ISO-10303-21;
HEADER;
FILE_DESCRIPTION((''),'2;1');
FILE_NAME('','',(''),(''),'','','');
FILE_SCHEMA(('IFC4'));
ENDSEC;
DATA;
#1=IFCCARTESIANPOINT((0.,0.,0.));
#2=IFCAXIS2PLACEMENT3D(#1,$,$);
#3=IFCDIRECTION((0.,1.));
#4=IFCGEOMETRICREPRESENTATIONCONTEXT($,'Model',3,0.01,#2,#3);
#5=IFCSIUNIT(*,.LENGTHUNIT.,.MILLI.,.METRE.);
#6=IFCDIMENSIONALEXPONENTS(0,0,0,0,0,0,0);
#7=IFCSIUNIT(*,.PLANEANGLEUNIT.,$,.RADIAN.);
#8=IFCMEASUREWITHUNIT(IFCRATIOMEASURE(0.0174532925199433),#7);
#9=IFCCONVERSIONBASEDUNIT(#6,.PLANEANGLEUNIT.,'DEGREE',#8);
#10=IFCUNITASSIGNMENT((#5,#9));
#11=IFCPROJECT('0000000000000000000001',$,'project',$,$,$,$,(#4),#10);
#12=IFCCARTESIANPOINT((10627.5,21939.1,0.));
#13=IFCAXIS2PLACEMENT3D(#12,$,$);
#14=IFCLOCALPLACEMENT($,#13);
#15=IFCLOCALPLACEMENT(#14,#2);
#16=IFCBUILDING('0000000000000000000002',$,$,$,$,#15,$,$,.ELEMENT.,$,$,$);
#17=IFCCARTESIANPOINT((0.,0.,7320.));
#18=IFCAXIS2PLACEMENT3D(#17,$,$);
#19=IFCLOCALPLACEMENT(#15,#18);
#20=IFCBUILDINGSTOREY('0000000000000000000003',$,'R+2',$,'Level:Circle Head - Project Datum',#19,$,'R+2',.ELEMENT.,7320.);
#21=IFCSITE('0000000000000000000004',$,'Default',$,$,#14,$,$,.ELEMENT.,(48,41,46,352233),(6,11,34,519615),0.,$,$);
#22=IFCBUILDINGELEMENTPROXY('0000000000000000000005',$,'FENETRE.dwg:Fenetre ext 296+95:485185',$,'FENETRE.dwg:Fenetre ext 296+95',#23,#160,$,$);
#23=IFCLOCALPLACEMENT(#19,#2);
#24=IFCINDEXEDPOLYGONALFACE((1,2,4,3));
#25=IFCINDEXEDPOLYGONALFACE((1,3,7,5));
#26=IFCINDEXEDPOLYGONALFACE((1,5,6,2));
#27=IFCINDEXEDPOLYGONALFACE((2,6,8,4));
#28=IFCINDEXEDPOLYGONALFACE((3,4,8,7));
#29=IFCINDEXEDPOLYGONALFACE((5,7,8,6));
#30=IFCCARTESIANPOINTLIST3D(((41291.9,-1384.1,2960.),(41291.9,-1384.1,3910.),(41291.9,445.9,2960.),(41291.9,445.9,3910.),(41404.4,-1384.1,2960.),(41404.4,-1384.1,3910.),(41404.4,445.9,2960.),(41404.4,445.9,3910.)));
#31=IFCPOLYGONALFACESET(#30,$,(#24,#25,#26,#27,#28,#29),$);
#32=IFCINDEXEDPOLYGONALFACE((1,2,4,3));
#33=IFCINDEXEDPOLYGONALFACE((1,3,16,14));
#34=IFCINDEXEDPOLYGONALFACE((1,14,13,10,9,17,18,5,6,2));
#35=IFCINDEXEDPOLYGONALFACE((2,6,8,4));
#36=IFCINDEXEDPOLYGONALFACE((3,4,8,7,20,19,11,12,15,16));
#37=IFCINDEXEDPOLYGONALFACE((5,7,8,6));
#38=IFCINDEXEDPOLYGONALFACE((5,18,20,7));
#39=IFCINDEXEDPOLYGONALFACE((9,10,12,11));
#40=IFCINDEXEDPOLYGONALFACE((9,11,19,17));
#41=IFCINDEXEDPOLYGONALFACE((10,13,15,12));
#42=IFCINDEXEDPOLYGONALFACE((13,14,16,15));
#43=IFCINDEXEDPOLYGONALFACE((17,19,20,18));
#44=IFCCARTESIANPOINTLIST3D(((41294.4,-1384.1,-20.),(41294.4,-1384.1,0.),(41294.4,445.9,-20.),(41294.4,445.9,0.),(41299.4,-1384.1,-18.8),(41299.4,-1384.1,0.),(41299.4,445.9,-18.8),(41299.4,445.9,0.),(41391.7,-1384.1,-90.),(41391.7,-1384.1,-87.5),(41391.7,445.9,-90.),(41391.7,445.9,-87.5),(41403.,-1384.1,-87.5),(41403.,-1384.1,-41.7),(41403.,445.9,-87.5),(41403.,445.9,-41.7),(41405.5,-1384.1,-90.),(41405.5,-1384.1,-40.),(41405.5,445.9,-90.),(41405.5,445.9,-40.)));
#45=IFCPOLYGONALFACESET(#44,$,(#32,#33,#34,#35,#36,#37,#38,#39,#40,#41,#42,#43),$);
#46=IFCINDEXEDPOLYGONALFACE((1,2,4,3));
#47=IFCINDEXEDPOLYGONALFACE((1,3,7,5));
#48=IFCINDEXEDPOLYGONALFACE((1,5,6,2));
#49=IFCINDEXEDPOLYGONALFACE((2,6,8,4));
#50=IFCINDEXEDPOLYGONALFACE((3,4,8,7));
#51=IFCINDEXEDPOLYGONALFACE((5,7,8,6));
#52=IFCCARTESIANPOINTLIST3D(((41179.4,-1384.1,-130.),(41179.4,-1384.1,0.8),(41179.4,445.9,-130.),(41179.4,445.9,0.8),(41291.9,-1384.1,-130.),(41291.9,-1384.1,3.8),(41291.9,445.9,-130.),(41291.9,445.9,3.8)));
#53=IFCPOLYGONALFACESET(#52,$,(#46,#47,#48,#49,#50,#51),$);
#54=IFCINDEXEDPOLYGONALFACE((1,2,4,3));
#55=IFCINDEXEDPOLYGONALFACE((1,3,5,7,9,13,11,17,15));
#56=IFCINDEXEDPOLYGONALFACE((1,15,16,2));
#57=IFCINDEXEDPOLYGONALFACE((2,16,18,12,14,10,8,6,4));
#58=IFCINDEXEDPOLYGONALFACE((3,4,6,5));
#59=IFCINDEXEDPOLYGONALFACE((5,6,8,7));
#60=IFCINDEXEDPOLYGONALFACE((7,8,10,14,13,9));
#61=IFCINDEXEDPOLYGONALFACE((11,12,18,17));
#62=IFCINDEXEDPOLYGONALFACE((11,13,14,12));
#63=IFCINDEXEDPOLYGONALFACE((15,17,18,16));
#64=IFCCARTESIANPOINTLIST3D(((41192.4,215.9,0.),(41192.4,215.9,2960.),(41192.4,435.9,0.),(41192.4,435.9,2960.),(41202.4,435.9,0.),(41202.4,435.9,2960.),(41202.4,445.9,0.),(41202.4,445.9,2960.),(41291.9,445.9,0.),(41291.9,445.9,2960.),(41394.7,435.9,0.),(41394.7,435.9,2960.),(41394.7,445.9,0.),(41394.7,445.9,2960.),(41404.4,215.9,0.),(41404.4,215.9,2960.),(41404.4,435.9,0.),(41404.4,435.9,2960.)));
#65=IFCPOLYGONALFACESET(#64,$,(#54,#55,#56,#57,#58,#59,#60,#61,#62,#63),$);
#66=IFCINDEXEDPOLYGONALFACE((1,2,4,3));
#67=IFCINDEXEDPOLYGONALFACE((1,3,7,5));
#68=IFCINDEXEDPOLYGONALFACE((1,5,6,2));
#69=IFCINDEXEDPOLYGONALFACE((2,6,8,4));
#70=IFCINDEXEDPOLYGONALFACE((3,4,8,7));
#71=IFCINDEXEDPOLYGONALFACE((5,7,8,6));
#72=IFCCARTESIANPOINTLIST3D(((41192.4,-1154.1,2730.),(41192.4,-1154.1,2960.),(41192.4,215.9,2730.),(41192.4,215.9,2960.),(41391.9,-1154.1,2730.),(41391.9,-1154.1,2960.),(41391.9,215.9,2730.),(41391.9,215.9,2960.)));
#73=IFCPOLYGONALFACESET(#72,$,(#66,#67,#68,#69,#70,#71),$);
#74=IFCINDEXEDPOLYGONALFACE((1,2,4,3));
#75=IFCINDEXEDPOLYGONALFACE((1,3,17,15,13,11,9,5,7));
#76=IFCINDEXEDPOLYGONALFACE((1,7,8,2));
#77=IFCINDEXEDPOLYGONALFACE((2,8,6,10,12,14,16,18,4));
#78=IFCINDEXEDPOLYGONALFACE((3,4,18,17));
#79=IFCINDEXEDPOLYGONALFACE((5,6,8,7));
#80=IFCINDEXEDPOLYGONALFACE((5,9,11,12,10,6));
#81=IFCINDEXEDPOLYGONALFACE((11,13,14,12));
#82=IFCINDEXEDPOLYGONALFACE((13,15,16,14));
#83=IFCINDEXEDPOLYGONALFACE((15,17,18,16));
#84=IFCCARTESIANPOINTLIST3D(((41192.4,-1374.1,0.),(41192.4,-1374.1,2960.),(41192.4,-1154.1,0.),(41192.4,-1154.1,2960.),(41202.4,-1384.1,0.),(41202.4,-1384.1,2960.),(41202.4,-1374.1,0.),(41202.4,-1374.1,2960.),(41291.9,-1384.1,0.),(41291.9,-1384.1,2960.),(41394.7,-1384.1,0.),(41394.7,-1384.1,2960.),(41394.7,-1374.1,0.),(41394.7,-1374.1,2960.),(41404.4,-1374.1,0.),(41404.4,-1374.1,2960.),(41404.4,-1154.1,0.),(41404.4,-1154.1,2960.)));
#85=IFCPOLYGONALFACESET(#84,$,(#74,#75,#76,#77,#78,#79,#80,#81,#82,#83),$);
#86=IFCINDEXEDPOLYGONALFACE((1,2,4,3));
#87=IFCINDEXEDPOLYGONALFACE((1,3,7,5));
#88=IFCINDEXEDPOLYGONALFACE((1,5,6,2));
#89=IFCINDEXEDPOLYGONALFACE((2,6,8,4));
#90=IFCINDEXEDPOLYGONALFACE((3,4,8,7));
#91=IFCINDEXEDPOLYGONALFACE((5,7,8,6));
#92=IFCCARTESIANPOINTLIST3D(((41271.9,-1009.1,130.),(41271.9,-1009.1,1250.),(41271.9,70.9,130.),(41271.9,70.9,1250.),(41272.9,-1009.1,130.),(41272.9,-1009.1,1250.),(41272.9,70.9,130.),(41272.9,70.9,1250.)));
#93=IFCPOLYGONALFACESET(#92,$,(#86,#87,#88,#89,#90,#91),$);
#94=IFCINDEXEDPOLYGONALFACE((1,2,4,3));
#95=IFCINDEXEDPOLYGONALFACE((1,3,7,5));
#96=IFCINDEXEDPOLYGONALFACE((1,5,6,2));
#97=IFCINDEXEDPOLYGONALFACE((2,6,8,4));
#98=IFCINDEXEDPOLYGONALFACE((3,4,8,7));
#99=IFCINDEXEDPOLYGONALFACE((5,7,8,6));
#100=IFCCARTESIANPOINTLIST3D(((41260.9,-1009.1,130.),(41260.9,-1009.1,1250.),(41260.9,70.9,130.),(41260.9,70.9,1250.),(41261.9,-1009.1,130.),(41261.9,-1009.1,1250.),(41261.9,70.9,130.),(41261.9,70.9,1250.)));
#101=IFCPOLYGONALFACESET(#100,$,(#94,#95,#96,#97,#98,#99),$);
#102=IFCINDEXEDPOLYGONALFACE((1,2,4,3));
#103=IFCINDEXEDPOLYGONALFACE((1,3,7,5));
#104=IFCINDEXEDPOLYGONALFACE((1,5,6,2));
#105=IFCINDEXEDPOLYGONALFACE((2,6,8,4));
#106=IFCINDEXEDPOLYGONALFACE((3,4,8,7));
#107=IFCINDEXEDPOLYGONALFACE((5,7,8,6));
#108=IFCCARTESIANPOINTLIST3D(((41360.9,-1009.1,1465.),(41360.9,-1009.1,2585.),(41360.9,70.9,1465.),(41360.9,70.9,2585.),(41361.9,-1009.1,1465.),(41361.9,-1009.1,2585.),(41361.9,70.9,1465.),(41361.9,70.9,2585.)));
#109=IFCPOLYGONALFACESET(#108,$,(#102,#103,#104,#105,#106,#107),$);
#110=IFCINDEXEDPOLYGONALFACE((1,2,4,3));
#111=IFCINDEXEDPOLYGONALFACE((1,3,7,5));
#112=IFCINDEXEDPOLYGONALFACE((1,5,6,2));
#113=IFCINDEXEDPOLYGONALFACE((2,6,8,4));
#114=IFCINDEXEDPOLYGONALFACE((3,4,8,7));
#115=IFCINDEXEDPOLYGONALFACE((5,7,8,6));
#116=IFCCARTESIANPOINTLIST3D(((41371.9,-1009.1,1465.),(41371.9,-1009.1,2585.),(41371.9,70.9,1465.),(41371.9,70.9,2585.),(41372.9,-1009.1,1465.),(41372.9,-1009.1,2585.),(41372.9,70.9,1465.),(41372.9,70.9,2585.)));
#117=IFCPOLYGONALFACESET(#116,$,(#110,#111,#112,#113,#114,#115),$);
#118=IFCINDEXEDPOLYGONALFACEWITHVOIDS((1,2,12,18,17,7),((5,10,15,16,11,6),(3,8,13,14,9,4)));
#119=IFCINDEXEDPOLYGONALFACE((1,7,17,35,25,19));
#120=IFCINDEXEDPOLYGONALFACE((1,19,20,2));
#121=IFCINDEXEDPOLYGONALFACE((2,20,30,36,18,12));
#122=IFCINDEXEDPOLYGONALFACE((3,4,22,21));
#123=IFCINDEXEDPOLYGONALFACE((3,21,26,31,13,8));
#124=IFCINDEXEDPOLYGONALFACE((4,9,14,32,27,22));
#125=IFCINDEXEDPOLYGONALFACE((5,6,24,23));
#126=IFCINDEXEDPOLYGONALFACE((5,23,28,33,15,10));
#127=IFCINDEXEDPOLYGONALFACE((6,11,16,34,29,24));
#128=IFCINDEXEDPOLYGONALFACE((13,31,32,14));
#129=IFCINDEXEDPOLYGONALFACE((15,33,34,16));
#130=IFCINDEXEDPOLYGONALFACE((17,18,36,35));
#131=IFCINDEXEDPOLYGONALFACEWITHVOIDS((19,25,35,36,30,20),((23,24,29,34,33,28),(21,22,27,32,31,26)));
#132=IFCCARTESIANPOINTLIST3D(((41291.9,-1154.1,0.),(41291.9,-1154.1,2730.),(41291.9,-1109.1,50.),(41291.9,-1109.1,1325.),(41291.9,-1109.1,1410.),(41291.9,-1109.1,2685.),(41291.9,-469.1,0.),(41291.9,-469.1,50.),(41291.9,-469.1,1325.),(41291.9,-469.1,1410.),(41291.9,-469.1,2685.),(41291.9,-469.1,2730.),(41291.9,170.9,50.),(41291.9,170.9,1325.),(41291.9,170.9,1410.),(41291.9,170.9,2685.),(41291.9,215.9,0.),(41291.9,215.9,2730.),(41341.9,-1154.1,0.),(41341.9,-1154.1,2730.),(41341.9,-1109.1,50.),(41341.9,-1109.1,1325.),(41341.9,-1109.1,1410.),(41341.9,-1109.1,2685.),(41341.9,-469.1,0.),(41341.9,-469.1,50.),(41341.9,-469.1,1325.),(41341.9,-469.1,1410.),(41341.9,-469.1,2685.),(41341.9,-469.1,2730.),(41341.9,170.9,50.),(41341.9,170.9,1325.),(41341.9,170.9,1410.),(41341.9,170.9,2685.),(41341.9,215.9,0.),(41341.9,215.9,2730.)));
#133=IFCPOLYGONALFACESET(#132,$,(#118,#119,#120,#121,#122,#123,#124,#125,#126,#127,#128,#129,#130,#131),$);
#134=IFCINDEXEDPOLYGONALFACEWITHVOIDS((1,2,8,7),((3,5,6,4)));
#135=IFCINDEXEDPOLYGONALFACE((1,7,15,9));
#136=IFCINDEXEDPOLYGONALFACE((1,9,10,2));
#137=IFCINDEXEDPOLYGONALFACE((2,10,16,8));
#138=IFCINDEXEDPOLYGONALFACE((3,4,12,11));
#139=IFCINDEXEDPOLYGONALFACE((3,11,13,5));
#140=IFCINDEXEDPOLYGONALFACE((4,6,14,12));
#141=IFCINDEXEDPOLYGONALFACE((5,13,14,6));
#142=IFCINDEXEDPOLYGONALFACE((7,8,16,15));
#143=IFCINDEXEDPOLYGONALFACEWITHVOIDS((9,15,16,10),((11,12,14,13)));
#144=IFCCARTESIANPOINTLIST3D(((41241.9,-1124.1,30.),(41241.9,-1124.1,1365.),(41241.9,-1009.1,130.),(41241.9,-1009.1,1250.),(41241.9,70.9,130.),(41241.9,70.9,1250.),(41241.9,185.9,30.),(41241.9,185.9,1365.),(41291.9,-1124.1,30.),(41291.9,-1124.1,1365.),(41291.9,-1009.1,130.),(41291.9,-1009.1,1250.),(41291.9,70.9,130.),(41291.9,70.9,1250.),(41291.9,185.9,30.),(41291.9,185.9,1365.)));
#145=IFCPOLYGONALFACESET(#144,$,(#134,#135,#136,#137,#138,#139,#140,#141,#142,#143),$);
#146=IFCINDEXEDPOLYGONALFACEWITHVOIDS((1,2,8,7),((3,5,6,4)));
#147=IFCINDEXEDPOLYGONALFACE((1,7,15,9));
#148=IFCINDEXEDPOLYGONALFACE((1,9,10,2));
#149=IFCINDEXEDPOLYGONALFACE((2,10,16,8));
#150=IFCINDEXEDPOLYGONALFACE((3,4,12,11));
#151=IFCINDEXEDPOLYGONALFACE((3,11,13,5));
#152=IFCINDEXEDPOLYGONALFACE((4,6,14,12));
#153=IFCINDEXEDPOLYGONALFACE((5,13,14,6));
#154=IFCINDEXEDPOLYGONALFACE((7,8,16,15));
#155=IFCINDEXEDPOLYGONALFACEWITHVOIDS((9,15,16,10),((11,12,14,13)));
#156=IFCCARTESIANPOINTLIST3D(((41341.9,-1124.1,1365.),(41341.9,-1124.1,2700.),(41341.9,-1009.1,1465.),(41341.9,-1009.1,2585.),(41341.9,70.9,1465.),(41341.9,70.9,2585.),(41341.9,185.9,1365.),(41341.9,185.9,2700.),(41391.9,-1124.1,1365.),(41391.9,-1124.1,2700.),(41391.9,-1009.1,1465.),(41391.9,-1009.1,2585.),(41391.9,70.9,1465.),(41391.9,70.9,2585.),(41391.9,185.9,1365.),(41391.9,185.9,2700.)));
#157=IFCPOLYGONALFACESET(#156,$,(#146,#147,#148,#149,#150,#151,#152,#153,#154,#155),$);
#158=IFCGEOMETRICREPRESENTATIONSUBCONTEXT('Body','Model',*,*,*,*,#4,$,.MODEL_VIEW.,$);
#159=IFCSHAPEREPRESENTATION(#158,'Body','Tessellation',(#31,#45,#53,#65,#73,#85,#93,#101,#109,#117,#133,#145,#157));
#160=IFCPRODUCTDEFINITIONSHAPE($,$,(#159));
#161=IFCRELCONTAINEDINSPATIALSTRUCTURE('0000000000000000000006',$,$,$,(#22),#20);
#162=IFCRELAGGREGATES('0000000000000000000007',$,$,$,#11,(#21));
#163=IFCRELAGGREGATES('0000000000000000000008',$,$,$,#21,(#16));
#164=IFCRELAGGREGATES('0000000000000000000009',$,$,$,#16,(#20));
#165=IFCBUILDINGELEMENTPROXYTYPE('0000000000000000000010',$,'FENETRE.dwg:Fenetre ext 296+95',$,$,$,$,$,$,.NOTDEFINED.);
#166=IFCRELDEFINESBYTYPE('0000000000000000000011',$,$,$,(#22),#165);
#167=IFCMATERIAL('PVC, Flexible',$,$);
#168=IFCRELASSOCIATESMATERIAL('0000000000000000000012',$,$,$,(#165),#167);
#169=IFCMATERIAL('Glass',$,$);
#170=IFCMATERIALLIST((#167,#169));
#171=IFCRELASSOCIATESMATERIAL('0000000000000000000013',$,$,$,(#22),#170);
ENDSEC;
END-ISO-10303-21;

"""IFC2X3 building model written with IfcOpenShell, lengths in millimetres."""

from ifc_helpers import new_model, entity, si_unit, converted_unit, direction, frame, frame_2d, origin, origin_2d_with_axis, place, context, subcontext, project, spatial, polyline, rectangle, outline, extrude, source, transform, mapped, material, material_list, type_object, type_shapes, element, save


model = new_model("IFC2X3")

# Units and contexts
model_context = context("Model", 3, precision=0.01, world=origin(), true_north=direction((0.0, 1.0)))
body_context = subcontext(model_context, "Body", "Model", "MODEL_VIEW")
ifc_project = project(units=[si_unit("LENGTHUNIT", "METRE", prefix="MILLI"), converted_unit("PLANEANGLEUNIT", "DEGREE", entity("IfcRatioMeasure", 0.0174532925199433), si_unit("PLANEANGLEUNIT", "RADIAN"), dimensions=[0, 0, 0, 0, 0, 0, 0])], contexts=[model_context])

# Site, building, storey
site_placement = place(None, frame((10627.5, 21939.1, 0.0)))
site = spatial("IfcSite", under=ifc_project, at=site_placement, Name="Default", CompositionType="ELEMENT", RefLatitude=(48, 41, 46, 352233), RefLongitude=(6, 11, 34, 519615), RefElevation=0.0)
building_placement = place(site_placement, origin())
building = spatial("IfcBuilding", under=site, at=building_placement, CompositionType="ELEMENT")
storey_placement = place(building_placement, frame((0.0, 0.0, 7320.0)))
storey = spatial("IfcBuildingStorey", under=building, at=storey_placement, Name="R+2", ObjectType="Level:Circle Head - Project Datum", LongName="R+2", CompositionType="ELEMENT", Elevation=7320.0)

# Building element proxy
ifc_material_1 = material(Name="PVC, Flexible")
ifc_material_2 = material(Name="Glass")
building_element_proxy_type_1 = type_object("IfcBuildingElementProxyType", Name="FENETRE.dwg:Fenetre ext 296+95", PredefinedType="NOTDEFINED", material=ifc_material_1)
shared_shape_1 = source(origin(), body_context, "Body", "SweptSolid", [
    extrude(rectangle(XDim=112.5, YDim=1830.0, at=origin_2d_with_axis()), frame((-10.4, -56.3, 2960.0), z_axis=(0.0, 0.0, 1.0), x_axis=(0.0, 1.0, 0.0)), (0.0, 0.0, 1.0), 950.0),
    extrude(outline(polyline([(27.5, -64.4), (47.5, -64.4), (47.5, -59.4), (28.8, -59.4), (7.5, 46.7), (-42.5, 46.7), (-42.5, 32.9), (-40.0, 32.9), (-40.0, 44.2), (5.8, 44.2), (27.5, -64.4)])), frame((-925.4, -66.9, -47.5), z_axis=(1.0, 0.0, 0.0), x_axis=(0.0, 0.0, 1.0)), (0.0, 0.0, 1.0), 1830.0),
    extrude(outline(polyline([(-54.5, -66.1), (58.0, -66.1), (54.5, 67.6), (-58.0, 64.6), (-54.5, -66.1)])), frame((-925.4, 56.3, -63.8), z_axis=(1.0, 0.0, 0.0), x_axis=(0.0, -0.999645, 0.02665)), (0.0, 0.0, 1.0), 1830.0),
    extrude(outline(polyline([(-97.0, -55.6), (5.9, -55.6), (95.4, -55.6), (95.4, -45.6), (105.4, -45.6), (105.4, 174.4), (-106.6, 174.4), (-106.6, -45.6), (-97.0, -45.6), (-97.0, -55.6)])), frame((849.0, -5.9, 0.0), z_axis=(0.0, 0.0, 1.0), x_axis=(0.0, 1.0, 0.0)), (0.0, 0.0, 1.0), 2960.0),
    extrude(rectangle(XDim=1370.0, YDim=199.5, at=origin_2d_with_axis()), frame((-10.4, -0.3, 2730.0), z_axis=(0.0, 0.0, 1.0), x_axis=(-1.0, 0.0, 0.0)), (0.0, 0.0, 1.0), 230.0),
    extrude(outline(polyline([(-55.6, 97.0), (-55.6, -5.9), (-55.6, -95.4), (-45.6, -95.4), (-45.6, -105.4), (174.4, -105.4), (174.4, 106.6), (-45.6, 106.6), (-45.6, 97.0), (-55.6, 97.0)])), frame((-869.9, -5.9, 0.0), z_axis=(0.0, 0.0, -1.0), x_axis=(1.0, 0.0, 0.0)), (0.0, 0.0, -1.0), 2960.0),
    extrude(rectangle(XDim=1080.0, YDim=1.0, at=origin_2d_with_axis()), frame((-10.4, 19.5, 130.0), z_axis=(0.0, 0.0, 1.0), x_axis=(-1.0, 0.0, 0.0)), (0.0, 0.0, 1.0), 1120.0),
    extrude(rectangle(XDim=1080.0, YDim=1.0, at=origin_2d_with_axis()), frame((-10.4, 30.5, 130.0), z_axis=(0.0, 0.0, 1.0), x_axis=(-1.0, 0.0, 0.0)), (0.0, 0.0, 1.0), 1120.0),
    extrude(rectangle(XDim=1080.0, YDim=1.0, at=frame_2d((0.0, 0.0), x_axis=(1.0, 0.0))), frame((-10.4, -69.5, 1465.0), z_axis=(0.0, 0.0, 1.0), x_axis=(-1.0, 0.0, 0.0)), (0.0, 0.0, 1.0), 1120.0),
    extrude(rectangle(XDim=1080.0, YDim=1.0, at=frame_2d((0.0, 0.0), x_axis=(1.0, 0.0))), frame((-10.4, -80.5, 1465.0), z_axis=(0.0, 0.0, 1.0), x_axis=(-1.0, 0.0, 0.0)), (0.0, 0.0, 1.0), 1120.0),
    extrude(outline(polyline([(-685.0, -1365.0), (0.0, -1365.0), (685.0, -1365.0), (685.0, 1365.0), (0.0, 1365.0), (-685.0, 1365.0), (-685.0, -1365.0)]), holes=[polyline([(-640.0, -1320.0), (-640.0, -45.0), (0.0, -45.0), (640.0, -45.0), (640.0, -1320.0), (0.0, -1320.0), (-640.0, -1320.0)]), polyline([(-640.0, 40.0), (-640.0, 1315.0), (0.0, 1315.0), (640.0, 1315.0), (640.0, 40.0), (0.0, 40.0), (-640.0, 40.0)])]), frame((-10.4, -50.0, 1365.0), z_axis=(0.0, 1.0, 0.0), x_axis=(1.0, 0.0, 0.0)), (0.0, 0.0, 1.0), 50.0),
    extrude(outline(polyline([(-655.0, -667.5), (655.0, -667.5), (655.0, 667.5), (-655.0, 667.5), (-655.0, -667.5)]), holes=[polyline([(-540.0, 552.5), (540.0, 552.5), (540.0, -567.5), (-540.0, -567.5), (-540.0, 552.5)])]), frame((-10.4, 0.0, 697.5), z_axis=(0.0, 1.0, 0.0), x_axis=(-1.0, 0.0, 0.0)), (0.0, 0.0, 1.0), 50.0),
    extrude(outline(polyline([(-655.0, -667.5), (655.0, -667.5), (655.0, 667.5), (-655.0, 667.5), (-655.0, -667.5)]), holes=[polyline([(-540.0, 552.5), (540.0, 552.5), (540.0, -567.5), (-540.0, -567.5), (-540.0, 552.5)])]), frame((-10.4, -100.0, 2032.5), z_axis=(0.0, 1.0, 0.0), x_axis=(-1.0, 0.0, 0.0)), (0.0, 0.0, 1.0), 50.0),
])
type_shapes(building_element_proxy_type_1, [shared_shape_1])
ifc_material_list_1 = material_list([ifc_material_1, ifc_material_2])
proxy_1_placement = place(storey_placement, frame((41291.9, -458.7, 0.0), z_axis=(0.0, 0.0, 1.0), x_axis=(0.0, 1.0, 0.0)))
element("IfcBuildingElementProxy", 1, at=proxy_1_placement, inside=storey, type_object=building_element_proxy_type_1, material=ifc_material_list_1, Name="FENETRE.dwg:Fenetre ext 296+95:485185", ObjectType="FENETRE.dwg:Fenetre ext 296+95", context=body_context, shape_type="MappedRepresentation", body=[
    mapped(shared_shape_1, transform((0.0, 0.0, 0.0), scale=1.0)),
])

save(model, "model.ifc")
